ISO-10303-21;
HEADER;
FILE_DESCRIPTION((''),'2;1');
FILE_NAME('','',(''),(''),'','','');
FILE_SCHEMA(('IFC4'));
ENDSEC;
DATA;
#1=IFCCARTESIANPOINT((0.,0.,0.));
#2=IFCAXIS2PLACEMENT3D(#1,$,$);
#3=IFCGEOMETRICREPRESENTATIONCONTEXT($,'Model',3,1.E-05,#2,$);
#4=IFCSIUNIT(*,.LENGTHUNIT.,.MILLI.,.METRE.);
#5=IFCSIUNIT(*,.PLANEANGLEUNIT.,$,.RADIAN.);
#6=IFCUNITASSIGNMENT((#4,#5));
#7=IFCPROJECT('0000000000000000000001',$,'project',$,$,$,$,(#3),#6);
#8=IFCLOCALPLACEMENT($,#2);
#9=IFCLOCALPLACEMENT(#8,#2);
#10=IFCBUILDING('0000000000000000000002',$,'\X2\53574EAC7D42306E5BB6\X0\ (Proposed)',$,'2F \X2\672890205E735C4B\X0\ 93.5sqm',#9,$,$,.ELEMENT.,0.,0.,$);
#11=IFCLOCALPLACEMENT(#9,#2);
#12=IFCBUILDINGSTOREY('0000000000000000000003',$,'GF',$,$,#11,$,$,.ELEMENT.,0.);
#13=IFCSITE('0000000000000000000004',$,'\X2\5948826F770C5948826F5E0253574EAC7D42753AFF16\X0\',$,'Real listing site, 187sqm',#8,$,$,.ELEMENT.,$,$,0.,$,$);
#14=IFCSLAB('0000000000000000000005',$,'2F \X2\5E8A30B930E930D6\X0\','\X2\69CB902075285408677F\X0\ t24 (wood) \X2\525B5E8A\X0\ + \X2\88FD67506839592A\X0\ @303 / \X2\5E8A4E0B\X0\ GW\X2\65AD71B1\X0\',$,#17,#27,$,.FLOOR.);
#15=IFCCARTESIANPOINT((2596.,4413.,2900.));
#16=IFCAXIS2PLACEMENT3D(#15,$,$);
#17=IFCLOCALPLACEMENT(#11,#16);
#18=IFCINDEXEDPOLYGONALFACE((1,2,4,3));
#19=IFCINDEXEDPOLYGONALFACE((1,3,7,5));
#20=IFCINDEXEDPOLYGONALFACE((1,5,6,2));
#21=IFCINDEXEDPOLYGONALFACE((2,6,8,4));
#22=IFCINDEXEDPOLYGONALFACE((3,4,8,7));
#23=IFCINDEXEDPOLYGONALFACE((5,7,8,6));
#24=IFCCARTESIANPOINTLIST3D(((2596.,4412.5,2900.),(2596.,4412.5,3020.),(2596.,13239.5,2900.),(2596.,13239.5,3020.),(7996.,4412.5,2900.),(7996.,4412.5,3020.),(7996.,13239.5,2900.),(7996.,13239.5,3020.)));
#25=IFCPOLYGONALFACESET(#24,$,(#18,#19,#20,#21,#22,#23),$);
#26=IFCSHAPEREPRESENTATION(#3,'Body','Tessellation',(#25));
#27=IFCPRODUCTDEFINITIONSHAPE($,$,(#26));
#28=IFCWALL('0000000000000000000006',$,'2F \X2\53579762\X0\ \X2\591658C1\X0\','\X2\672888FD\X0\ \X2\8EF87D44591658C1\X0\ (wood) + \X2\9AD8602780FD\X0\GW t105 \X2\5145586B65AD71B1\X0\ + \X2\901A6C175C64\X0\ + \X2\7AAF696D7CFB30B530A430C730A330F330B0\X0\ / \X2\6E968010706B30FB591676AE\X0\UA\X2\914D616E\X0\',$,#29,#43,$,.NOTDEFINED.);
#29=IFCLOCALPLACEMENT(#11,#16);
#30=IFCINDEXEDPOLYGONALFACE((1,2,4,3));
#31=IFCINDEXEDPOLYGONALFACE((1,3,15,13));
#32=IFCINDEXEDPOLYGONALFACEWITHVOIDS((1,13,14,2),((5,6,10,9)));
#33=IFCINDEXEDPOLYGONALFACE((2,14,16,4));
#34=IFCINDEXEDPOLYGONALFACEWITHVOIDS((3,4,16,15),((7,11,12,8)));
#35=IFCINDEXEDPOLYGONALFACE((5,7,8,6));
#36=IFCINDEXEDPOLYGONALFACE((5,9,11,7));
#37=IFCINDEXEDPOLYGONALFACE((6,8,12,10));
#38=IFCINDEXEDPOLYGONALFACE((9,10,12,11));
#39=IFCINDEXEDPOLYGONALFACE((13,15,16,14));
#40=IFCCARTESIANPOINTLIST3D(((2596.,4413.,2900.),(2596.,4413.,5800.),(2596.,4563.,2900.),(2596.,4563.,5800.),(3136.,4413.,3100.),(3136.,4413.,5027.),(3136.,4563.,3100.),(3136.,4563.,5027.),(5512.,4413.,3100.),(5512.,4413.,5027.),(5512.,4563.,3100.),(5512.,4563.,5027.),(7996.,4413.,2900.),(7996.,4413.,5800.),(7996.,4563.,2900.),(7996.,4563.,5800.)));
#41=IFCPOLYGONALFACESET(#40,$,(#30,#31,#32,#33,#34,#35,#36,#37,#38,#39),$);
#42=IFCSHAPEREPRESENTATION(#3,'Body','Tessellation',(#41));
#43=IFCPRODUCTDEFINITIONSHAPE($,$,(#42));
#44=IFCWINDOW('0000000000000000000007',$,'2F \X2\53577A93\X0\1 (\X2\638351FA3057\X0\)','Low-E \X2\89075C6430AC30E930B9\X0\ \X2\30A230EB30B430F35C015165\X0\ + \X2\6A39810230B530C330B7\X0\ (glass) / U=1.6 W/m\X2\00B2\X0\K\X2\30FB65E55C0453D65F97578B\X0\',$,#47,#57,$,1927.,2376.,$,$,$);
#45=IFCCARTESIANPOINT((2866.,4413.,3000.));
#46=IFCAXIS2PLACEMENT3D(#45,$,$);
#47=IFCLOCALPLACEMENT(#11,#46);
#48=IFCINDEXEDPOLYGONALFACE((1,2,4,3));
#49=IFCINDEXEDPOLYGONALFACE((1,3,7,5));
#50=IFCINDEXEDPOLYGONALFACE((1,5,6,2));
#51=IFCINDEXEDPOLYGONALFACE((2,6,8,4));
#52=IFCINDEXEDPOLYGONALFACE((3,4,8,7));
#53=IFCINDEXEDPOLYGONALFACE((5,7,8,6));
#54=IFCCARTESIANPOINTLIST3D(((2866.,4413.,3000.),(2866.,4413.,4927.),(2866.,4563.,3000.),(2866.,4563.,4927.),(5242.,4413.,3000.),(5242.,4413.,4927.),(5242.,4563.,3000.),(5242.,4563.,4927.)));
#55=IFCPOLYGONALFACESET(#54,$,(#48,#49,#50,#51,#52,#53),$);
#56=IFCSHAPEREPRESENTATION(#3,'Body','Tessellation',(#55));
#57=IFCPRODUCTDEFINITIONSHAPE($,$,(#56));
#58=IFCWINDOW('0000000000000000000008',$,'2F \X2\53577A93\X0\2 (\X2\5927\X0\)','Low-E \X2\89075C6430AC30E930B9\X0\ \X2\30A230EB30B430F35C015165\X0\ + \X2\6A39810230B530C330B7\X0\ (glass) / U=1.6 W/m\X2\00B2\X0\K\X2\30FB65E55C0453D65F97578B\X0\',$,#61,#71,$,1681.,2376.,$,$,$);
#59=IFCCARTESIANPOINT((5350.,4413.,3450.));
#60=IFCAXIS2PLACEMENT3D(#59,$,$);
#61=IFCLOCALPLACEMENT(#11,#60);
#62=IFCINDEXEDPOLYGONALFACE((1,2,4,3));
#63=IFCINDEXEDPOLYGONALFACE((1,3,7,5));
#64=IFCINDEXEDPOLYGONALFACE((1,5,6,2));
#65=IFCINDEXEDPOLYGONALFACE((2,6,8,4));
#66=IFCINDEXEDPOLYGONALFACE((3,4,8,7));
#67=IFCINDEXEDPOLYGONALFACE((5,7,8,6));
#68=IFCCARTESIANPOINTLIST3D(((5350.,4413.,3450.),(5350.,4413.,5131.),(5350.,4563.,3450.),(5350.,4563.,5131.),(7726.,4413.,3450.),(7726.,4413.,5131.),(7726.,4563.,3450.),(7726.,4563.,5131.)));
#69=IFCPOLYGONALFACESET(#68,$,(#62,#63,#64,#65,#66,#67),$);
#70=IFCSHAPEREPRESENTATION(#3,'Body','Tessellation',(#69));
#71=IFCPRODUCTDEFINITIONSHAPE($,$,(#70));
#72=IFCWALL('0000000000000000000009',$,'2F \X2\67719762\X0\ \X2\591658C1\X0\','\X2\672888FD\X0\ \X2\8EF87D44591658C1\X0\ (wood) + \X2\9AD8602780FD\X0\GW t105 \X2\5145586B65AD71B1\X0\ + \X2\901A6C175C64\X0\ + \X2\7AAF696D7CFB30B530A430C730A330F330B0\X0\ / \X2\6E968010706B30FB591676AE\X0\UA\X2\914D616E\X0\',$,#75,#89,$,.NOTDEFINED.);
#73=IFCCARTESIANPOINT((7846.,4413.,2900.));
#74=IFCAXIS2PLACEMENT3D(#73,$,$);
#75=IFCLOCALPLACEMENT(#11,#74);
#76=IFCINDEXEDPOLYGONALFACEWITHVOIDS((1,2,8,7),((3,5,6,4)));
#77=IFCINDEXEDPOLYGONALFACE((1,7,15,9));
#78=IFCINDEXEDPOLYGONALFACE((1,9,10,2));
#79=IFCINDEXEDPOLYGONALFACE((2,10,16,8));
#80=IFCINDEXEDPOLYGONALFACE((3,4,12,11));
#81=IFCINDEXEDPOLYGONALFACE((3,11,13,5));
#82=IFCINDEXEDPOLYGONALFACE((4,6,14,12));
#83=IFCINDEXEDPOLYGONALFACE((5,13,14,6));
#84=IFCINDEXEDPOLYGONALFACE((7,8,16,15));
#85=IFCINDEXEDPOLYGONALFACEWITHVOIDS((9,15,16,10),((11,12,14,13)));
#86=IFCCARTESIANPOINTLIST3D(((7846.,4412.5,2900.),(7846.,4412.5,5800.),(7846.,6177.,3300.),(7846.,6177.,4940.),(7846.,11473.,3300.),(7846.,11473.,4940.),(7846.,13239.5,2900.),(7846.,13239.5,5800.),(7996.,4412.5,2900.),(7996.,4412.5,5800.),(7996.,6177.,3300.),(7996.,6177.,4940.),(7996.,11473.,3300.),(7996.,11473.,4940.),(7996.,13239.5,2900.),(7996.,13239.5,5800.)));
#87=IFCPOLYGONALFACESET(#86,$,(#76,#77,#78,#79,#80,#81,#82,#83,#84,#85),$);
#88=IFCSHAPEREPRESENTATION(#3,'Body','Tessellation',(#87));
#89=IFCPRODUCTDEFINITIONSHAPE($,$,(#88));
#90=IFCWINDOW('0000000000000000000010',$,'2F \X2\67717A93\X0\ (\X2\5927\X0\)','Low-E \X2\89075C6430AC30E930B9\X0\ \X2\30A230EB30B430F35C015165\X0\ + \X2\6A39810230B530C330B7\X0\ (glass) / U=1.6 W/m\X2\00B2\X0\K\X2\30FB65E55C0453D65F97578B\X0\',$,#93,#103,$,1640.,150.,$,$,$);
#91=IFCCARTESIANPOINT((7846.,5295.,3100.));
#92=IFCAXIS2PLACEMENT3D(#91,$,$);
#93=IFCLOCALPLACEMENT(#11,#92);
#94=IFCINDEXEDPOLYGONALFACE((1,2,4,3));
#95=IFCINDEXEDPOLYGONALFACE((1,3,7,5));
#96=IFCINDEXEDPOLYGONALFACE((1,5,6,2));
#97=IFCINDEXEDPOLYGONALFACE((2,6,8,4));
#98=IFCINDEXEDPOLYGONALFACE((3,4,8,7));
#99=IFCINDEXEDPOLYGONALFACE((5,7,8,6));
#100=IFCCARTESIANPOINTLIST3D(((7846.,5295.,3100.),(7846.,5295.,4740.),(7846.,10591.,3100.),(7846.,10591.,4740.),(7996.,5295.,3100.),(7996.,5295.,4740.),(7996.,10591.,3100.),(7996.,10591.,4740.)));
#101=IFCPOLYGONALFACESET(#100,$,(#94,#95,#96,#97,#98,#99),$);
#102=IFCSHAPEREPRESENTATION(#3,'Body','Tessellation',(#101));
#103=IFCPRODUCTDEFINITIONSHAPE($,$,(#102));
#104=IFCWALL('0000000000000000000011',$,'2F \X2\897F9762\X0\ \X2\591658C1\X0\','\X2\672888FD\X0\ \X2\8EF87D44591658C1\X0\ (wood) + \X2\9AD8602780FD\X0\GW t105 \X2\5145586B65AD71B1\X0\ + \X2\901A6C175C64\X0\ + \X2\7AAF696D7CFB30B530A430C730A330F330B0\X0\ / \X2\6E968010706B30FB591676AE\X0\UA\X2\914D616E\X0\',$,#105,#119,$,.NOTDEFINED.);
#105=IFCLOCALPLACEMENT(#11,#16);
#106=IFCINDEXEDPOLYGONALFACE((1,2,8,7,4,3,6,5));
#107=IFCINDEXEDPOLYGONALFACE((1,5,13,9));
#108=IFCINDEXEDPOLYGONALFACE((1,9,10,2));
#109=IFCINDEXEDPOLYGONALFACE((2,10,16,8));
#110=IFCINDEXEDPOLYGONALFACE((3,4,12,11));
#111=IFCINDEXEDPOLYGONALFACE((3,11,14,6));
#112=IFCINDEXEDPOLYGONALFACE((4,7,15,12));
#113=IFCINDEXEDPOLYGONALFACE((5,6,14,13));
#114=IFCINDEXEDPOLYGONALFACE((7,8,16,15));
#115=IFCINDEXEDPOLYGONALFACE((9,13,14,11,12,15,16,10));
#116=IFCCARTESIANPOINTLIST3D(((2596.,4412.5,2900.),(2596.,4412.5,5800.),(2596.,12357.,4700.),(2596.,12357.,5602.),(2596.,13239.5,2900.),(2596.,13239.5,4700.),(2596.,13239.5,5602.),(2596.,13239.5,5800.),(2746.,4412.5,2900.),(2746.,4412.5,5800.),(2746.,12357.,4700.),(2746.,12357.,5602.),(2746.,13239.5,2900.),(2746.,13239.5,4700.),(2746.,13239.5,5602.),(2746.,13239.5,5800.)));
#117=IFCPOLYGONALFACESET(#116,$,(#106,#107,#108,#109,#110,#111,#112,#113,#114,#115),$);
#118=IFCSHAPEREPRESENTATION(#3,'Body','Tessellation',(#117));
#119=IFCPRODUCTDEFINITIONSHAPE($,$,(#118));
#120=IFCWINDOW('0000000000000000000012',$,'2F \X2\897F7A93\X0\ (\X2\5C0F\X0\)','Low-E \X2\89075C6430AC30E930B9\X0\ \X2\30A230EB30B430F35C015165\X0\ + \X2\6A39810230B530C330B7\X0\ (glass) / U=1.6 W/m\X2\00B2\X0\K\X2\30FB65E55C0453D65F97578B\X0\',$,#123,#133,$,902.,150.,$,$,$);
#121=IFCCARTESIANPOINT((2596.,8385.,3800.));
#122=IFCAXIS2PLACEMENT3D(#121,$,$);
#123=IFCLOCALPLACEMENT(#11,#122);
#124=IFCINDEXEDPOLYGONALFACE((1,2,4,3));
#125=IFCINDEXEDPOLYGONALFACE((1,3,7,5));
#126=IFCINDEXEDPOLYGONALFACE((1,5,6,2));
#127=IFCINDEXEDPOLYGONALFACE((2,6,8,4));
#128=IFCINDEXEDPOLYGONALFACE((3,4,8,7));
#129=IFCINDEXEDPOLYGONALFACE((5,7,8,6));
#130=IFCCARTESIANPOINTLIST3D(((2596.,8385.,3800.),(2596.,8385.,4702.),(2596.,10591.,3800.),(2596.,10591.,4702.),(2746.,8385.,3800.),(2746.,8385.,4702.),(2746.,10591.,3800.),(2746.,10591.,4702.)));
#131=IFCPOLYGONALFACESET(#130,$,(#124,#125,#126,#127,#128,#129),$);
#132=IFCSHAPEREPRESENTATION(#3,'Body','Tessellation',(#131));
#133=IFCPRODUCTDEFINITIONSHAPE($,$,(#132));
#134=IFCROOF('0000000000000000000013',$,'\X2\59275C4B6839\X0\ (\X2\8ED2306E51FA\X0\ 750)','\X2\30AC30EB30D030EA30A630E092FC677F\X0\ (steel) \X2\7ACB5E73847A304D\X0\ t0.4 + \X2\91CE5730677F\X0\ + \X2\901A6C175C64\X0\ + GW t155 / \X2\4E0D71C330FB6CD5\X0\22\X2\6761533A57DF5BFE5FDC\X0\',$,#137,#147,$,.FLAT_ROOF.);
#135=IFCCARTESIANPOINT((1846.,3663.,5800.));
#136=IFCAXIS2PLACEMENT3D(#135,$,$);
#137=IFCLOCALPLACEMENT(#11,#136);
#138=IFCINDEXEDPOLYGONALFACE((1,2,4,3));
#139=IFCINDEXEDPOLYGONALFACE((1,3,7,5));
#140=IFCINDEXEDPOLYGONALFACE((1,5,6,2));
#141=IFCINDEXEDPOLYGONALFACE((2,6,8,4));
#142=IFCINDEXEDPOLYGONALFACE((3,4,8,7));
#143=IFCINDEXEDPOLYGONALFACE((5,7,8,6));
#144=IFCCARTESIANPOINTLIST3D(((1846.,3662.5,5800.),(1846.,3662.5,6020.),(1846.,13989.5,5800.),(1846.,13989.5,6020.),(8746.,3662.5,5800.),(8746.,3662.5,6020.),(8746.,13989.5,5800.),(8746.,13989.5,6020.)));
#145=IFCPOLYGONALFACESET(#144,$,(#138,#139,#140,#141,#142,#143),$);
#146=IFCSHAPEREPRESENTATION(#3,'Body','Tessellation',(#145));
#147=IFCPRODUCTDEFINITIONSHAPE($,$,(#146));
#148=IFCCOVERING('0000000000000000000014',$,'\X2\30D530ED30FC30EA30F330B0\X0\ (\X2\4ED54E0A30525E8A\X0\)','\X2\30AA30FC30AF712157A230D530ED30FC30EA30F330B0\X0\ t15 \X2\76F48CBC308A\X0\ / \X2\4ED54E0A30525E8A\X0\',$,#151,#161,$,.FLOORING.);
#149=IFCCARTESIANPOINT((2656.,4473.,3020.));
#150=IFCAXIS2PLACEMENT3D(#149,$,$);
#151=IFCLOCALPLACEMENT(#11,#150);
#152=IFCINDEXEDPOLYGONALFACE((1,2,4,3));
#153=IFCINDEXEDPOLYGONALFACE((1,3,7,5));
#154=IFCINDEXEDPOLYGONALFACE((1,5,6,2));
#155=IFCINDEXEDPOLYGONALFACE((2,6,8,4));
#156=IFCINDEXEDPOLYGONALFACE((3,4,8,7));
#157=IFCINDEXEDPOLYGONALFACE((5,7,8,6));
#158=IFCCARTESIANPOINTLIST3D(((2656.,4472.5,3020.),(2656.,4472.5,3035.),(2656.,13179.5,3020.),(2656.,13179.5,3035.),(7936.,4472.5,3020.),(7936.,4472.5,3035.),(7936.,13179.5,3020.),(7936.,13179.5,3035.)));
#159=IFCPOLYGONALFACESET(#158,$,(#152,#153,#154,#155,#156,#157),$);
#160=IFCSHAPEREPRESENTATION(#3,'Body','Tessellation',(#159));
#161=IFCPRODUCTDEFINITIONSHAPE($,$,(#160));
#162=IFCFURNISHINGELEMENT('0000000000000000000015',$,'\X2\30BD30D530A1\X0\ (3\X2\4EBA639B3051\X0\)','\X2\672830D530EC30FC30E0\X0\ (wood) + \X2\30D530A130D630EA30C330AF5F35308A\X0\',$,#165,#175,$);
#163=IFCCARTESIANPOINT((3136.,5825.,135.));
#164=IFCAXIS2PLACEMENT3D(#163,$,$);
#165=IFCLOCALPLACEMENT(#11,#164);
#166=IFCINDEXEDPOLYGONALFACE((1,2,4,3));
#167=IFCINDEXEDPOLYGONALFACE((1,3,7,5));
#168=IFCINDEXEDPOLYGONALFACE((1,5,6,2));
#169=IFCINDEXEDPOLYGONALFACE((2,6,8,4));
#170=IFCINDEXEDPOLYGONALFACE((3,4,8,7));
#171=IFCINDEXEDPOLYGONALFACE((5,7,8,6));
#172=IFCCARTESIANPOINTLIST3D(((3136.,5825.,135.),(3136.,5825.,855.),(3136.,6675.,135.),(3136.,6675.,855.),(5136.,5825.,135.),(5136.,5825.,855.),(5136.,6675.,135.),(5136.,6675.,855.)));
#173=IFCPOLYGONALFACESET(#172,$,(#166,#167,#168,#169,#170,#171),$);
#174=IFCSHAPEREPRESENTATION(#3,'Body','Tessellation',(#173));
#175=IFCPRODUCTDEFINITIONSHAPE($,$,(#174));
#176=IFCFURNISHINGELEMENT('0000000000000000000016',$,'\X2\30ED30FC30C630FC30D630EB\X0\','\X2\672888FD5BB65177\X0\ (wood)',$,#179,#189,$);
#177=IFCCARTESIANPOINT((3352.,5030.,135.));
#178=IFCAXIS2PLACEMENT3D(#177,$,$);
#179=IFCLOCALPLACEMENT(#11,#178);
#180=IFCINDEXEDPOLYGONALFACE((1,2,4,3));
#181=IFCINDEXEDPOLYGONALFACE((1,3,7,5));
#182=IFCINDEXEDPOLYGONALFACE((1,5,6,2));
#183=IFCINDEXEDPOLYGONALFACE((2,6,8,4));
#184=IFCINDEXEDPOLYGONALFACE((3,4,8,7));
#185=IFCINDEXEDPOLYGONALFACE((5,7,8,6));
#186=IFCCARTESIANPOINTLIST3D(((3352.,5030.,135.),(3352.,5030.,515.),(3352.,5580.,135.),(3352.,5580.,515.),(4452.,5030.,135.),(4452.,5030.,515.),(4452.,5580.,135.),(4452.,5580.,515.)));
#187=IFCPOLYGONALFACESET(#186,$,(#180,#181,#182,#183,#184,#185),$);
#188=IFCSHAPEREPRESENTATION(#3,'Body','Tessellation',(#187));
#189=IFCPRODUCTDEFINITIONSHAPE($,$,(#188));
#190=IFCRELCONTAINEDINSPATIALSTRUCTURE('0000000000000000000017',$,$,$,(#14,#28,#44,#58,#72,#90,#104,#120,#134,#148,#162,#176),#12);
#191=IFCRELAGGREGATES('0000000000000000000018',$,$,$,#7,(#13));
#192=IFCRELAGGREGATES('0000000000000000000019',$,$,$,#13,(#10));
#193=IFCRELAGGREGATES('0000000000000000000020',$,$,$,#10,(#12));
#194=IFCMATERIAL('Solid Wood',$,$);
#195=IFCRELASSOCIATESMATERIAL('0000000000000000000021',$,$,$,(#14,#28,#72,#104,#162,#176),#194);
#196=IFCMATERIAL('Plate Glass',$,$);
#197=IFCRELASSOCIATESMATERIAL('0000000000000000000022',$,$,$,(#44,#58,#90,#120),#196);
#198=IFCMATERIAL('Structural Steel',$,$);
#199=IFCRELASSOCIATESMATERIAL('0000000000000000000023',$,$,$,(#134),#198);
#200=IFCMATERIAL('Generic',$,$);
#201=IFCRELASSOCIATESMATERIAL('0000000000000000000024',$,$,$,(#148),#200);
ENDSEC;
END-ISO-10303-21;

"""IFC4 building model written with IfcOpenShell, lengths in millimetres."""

from ifc_helpers import new_model, si_unit, frame, frame_2d, origin, place, context, project, spatial, rectangle, extrude, material, element, fill, save


model = new_model("IFC4")

# Units and contexts
model_context = context("Model", 3, precision=1e-05, world=origin())
ifc_project = project(units=[si_unit("LENGTHUNIT", "METRE", prefix="MILLI"), si_unit("PLANEANGLEUNIT", "RADIAN")], contexts=[model_context])

# Site, building, storey
site_placement = place(None, origin())
site = spatial("IfcSite", under=ifc_project, at=site_placement, Name="奈良県奈良市南京終町６", ObjectType="Real listing site, 187sqm", CompositionType="ELEMENT", RefElevation=0.0)
building_placement = place(site_placement, origin())
building = spatial("IfcBuilding", under=site, at=building_placement, Name="南京終の家 (Proposed)", ObjectType="2F 木造平屋 93.5sqm", CompositionType="ELEMENT", ElevationOfRefHeight=0.0, ElevationOfTerrain=0.0)
storey_placement = place(building_placement, origin())
storey = spatial("IfcBuildingStorey", under=building, at=storey_placement, Name="GF", CompositionType="ELEMENT", Elevation=0.0)

# Slab
ifc_material_1 = material(Name="Solid Wood")
slab_placement = place(storey_placement, frame((2596.0, 4413.0, 2900.0)))
element("IfcSlab", 1, at=slab_placement, inside=storey, material=ifc_material_1, Name="2F 床スラブ", Description="構造用合板 t24 (wood) 剛床 + 製材根太 @303 / 床下 GW断熱", PredefinedType="FLOOR", context=model_context, shape_type="SweptSolid", body=[
    extrude(rectangle(XDim=5400.0, YDim=8827.0, at=frame_2d((2700.0, 4413.0))), frame((2596.0, 4413.0, 2900.0)), (0.0, 0.0, 1.0), 120.0),
])

# Wall, openings, windows
wall_1_placement = place(storey_placement, frame((2596.0, 4413.0, 2900.0)))
wall_1 = element("IfcWall", 2, at=wall_1_placement, inside=storey, material=ifc_material_1, Name="2F 南面 外壁", Description="木製 軸組外壁 (wood) + 高性能GW t105 充填断熱 + 通気層 + 窯業系サイディング / 準耐火・外皮UA配慮", PredefinedType="NOTDEFINED", context=model_context, shape_type="SweptSolid", body=[
    extrude(rectangle(XDim=5400.0, YDim=150.0, at=frame_2d((2700.0, 75.0))), frame((2596.0, 4413.0, 2900.0)), (0.0, 0.0, 1.0), 2900.0),
])
opening_1_placement = place(storey_placement, frame((2866.0, 4413.0, 3000.0)))
opening_1 = element("IfcOpeningElement", 3, at=opening_1_placement, cuts=wall_1, PredefinedType="NOTDEFINED", context=model_context, shape_type="SweptSolid", body=[
    extrude(rectangle(XDim=2376.0, YDim=150.0, at=frame_2d((1188.0, 75.0))), frame((2866.0, 4413.0, 3000.0)), (0.0, 0.0, 1.0), 1927.0),
])
opening_2_placement = place(storey_placement, frame((5350.0, 4413.0, 3450.0)))
opening_2 = element("IfcOpeningElement", 4, at=opening_2_placement, cuts=wall_1, PredefinedType="NOTDEFINED", context=model_context, shape_type="SweptSolid", body=[
    extrude(rectangle(XDim=2376.0, YDim=150.0, at=frame_2d((1188.0, 75.0))), frame((5350.0, 4413.0, 3450.0)), (0.0, 0.0, 1.0), 1681.0),
])
ifc_material_2 = material(Name="Plate Glass")
window_1_placement = place(storey_placement, frame((2866.0, 4413.0, 3000.0)))
window_1 = element("IfcWindow", 5, at=window_1_placement, inside=storey, material=ifc_material_2, Name="2F 南窓1 (掃出し)", Description="Low-E 複層ガラス アルゴン封入 + 樹脂サッシ (glass) / U=1.6 W/m²K・日射取得型", OverallHeight=1927.0, OverallWidth=2376.0, context=model_context, shape_type="SweptSolid", body=[
    extrude(rectangle(XDim=2376.0, YDim=150.0, at=frame_2d((1188.0, 75.0))), frame((2866.0, 4413.0, 3000.0)), (0.0, 0.0, 1.0), 1927.0),
])
fill(opening_1, window_1)
window_2_placement = place(storey_placement, frame((5350.0, 4413.0, 3450.0)))
window_2 = element("IfcWindow", 6, at=window_2_placement, inside=storey, material=ifc_material_2, Name="2F 南窓2 (大)", Description="Low-E 複層ガラス アルゴン封入 + 樹脂サッシ (glass) / U=1.6 W/m²K・日射取得型", OverallHeight=1681.0, OverallWidth=2376.0, context=model_context, shape_type="SweptSolid", body=[
    extrude(rectangle(XDim=2376.0, YDim=150.0, at=frame_2d((1188.0, 75.0))), frame((5350.0, 4413.0, 3450.0)), (0.0, 0.0, 1.0), 1681.0),
])
fill(opening_2, window_2)

# Walls, openings, windows
wall_2_placement = place(storey_placement, frame((7846.0, 4413.0, 2900.0)))
wall_2 = element("IfcWall", 7, at=wall_2_placement, inside=storey, material=ifc_material_1, Name="2F 東面 外壁", Description="木製 軸組外壁 (wood) + 高性能GW t105 充填断熱 + 通気層 + 窯業系サイディング / 準耐火・外皮UA配慮", PredefinedType="NOTDEFINED", context=model_context, shape_type="SweptSolid", body=[
    extrude(rectangle(XDim=150.0, YDim=8827.0, at=frame_2d((75.0, 4413.0))), frame((7846.0, 4413.0, 2900.0)), (0.0, 0.0, 1.0), 2900.0),
])
opening_3_placement = place(storey_placement, frame((7846.0, 5295.0, 3100.0)))
opening_3 = element("IfcOpeningElement", 8, at=opening_3_placement, cuts=wall_2, PredefinedType="NOTDEFINED", context=model_context, shape_type="SweptSolid", body=[
    extrude(rectangle(XDim=150.0, YDim=5296.0, at=frame_2d((75.0, 2648.0))), frame((7846.0, 5295.0, 3100.0)), (0.0, 0.0, 1.0), 1640.0),
])
window_3_placement = place(storey_placement, frame((7846.0, 5295.0, 3100.0)))
window_3 = element("IfcWindow", 9, at=window_3_placement, inside=storey, material=ifc_material_2, Name="2F 東窓 (大)", Description="Low-E 複層ガラス アルゴン封入 + 樹脂サッシ (glass) / U=1.6 W/m²K・日射取得型", OverallHeight=1640.0, OverallWidth=150.0, context=model_context, shape_type="SweptSolid", body=[
    extrude(rectangle(XDim=150.0, YDim=5296.0, at=frame_2d((75.0, 2648.0))), frame((7846.0, 5295.0, 3100.0)), (0.0, 0.0, 1.0), 1640.0),
])
fill(opening_3, window_3)
wall_3_placement = place(storey_placement, frame((2596.0, 4413.0, 2900.0)))
wall_3 = element("IfcWall", 10, at=wall_3_placement, inside=storey, material=ifc_material_1, Name="2F 西面 外壁", Description="木製 軸組外壁 (wood) + 高性能GW t105 充填断熱 + 通気層 + 窯業系サイディング / 準耐火・外皮UA配慮", PredefinedType="NOTDEFINED", context=model_context, shape_type="SweptSolid", body=[
    extrude(rectangle(XDim=150.0, YDim=8827.0, at=frame_2d((75.0, 4413.0))), frame((2596.0, 4413.0, 2900.0)), (0.0, 0.0, 1.0), 2900.0),
])
opening_4_placement = place(storey_placement, frame((2596.0, 8385.0, 3800.0)))
opening_4 = element("IfcOpeningElement", 11, at=opening_4_placement, cuts=wall_3, PredefinedType="NOTDEFINED", context=model_context, shape_type="SweptSolid", body=[
    extrude(rectangle(XDim=150.0, YDim=2206.0, at=frame_2d((75.0, 1103.0))), frame((2596.0, 8385.0, 3800.0)), (0.0, 0.0, 1.0), 902.0),
])
window_4_placement = place(storey_placement, frame((2596.0, 8385.0, 3800.0)))
window_4 = element("IfcWindow", 12, at=window_4_placement, inside=storey, material=ifc_material_2, Name="2F 西窓 (小)", Description="Low-E 複層ガラス アルゴン封入 + 樹脂サッシ (glass) / U=1.6 W/m²K・日射取得型", OverallHeight=902.0, OverallWidth=150.0, context=model_context, shape_type="SweptSolid", body=[
    extrude(rectangle(XDim=150.0, YDim=2206.0, at=frame_2d((75.0, 1103.0))), frame((2596.0, 8385.0, 3800.0)), (0.0, 0.0, 1.0), 902.0),
])
fill(opening_4, window_4)

# Roof
ifc_material_3 = material(Name="Structural Steel")
roof_placement = place(storey_placement, frame((1846.0, 3663.0, 5800.0)))
element("IfcRoof", 13, at=roof_placement, inside=storey, material=ifc_material_3, Name="大屋根 (軒の出 750)", Description="ガルバリウム鋼板 (steel) 立平葺き t0.4 + 野地板 + 通気層 + GW t155 / 不燃・法22条区域対応", PredefinedType="FLAT_ROOF", context=model_context, shape_type="SweptSolid", body=[
    extrude(rectangle(XDim=6900.0, YDim=10327.0, at=frame_2d((3450.0, 5163.0))), frame((1846.0, 3663.0, 5800.0)), (0.0, 0.0, 1.0), 220.0),
])

# Covering
ifc_material_4 = material(Name="Generic")
covering_placement = place(storey_placement, frame((2656.0, 4473.0, 3020.0)))
element("IfcCovering", 14, at=covering_placement, inside=storey, material=ifc_material_4, Name="フローリング (仕上げ床)", Description="オーク無垢フローリング t15 直貼り / 仕上げ床", PredefinedType="FLOORING", context=model_context, shape_type="SweptSolid", body=[
    extrude(rectangle(XDim=5280.0, YDim=8707.0, at=frame_2d((2640.0, 4353.0))), frame((2656.0, 4473.0, 3020.0)), (0.0, 0.0, 1.0), 15.0),
])

# Furnishing elements
furnishing_1_placement = place(storey_placement, frame((3136.0, 5825.0, 135.0)))
element("IfcFurnishingElement", 15, at=furnishing_1_placement, inside=storey, material=ifc_material_1, Name="ソファ (3人掛け)", Description="木フレーム (wood) + ファブリック張り", context=model_context, shape_type="SweptSolid", body=[
    extrude(rectangle(XDim=2000.0, YDim=850.0, at=frame_2d((1000.0, 425.0))), frame((3136.0, 5825.0, 135.0)), (0.0, 0.0, 1.0), 720.0),
])
furnishing_2_placement = place(storey_placement, frame((3352.0, 5030.0, 135.0)))
element("IfcFurnishingElement", 16, at=furnishing_2_placement, inside=storey, material=ifc_material_1, Name="ローテーブル", Description="木製家具 (wood)", context=model_context, shape_type="SweptSolid", body=[
    extrude(rectangle(XDim=1100.0, YDim=550.0, at=frame_2d((550.0, 275.0))), frame((3352.0, 5030.0, 135.0)), (0.0, 0.0, 1.0), 380.0),
])

save(model, "model.ifc")
